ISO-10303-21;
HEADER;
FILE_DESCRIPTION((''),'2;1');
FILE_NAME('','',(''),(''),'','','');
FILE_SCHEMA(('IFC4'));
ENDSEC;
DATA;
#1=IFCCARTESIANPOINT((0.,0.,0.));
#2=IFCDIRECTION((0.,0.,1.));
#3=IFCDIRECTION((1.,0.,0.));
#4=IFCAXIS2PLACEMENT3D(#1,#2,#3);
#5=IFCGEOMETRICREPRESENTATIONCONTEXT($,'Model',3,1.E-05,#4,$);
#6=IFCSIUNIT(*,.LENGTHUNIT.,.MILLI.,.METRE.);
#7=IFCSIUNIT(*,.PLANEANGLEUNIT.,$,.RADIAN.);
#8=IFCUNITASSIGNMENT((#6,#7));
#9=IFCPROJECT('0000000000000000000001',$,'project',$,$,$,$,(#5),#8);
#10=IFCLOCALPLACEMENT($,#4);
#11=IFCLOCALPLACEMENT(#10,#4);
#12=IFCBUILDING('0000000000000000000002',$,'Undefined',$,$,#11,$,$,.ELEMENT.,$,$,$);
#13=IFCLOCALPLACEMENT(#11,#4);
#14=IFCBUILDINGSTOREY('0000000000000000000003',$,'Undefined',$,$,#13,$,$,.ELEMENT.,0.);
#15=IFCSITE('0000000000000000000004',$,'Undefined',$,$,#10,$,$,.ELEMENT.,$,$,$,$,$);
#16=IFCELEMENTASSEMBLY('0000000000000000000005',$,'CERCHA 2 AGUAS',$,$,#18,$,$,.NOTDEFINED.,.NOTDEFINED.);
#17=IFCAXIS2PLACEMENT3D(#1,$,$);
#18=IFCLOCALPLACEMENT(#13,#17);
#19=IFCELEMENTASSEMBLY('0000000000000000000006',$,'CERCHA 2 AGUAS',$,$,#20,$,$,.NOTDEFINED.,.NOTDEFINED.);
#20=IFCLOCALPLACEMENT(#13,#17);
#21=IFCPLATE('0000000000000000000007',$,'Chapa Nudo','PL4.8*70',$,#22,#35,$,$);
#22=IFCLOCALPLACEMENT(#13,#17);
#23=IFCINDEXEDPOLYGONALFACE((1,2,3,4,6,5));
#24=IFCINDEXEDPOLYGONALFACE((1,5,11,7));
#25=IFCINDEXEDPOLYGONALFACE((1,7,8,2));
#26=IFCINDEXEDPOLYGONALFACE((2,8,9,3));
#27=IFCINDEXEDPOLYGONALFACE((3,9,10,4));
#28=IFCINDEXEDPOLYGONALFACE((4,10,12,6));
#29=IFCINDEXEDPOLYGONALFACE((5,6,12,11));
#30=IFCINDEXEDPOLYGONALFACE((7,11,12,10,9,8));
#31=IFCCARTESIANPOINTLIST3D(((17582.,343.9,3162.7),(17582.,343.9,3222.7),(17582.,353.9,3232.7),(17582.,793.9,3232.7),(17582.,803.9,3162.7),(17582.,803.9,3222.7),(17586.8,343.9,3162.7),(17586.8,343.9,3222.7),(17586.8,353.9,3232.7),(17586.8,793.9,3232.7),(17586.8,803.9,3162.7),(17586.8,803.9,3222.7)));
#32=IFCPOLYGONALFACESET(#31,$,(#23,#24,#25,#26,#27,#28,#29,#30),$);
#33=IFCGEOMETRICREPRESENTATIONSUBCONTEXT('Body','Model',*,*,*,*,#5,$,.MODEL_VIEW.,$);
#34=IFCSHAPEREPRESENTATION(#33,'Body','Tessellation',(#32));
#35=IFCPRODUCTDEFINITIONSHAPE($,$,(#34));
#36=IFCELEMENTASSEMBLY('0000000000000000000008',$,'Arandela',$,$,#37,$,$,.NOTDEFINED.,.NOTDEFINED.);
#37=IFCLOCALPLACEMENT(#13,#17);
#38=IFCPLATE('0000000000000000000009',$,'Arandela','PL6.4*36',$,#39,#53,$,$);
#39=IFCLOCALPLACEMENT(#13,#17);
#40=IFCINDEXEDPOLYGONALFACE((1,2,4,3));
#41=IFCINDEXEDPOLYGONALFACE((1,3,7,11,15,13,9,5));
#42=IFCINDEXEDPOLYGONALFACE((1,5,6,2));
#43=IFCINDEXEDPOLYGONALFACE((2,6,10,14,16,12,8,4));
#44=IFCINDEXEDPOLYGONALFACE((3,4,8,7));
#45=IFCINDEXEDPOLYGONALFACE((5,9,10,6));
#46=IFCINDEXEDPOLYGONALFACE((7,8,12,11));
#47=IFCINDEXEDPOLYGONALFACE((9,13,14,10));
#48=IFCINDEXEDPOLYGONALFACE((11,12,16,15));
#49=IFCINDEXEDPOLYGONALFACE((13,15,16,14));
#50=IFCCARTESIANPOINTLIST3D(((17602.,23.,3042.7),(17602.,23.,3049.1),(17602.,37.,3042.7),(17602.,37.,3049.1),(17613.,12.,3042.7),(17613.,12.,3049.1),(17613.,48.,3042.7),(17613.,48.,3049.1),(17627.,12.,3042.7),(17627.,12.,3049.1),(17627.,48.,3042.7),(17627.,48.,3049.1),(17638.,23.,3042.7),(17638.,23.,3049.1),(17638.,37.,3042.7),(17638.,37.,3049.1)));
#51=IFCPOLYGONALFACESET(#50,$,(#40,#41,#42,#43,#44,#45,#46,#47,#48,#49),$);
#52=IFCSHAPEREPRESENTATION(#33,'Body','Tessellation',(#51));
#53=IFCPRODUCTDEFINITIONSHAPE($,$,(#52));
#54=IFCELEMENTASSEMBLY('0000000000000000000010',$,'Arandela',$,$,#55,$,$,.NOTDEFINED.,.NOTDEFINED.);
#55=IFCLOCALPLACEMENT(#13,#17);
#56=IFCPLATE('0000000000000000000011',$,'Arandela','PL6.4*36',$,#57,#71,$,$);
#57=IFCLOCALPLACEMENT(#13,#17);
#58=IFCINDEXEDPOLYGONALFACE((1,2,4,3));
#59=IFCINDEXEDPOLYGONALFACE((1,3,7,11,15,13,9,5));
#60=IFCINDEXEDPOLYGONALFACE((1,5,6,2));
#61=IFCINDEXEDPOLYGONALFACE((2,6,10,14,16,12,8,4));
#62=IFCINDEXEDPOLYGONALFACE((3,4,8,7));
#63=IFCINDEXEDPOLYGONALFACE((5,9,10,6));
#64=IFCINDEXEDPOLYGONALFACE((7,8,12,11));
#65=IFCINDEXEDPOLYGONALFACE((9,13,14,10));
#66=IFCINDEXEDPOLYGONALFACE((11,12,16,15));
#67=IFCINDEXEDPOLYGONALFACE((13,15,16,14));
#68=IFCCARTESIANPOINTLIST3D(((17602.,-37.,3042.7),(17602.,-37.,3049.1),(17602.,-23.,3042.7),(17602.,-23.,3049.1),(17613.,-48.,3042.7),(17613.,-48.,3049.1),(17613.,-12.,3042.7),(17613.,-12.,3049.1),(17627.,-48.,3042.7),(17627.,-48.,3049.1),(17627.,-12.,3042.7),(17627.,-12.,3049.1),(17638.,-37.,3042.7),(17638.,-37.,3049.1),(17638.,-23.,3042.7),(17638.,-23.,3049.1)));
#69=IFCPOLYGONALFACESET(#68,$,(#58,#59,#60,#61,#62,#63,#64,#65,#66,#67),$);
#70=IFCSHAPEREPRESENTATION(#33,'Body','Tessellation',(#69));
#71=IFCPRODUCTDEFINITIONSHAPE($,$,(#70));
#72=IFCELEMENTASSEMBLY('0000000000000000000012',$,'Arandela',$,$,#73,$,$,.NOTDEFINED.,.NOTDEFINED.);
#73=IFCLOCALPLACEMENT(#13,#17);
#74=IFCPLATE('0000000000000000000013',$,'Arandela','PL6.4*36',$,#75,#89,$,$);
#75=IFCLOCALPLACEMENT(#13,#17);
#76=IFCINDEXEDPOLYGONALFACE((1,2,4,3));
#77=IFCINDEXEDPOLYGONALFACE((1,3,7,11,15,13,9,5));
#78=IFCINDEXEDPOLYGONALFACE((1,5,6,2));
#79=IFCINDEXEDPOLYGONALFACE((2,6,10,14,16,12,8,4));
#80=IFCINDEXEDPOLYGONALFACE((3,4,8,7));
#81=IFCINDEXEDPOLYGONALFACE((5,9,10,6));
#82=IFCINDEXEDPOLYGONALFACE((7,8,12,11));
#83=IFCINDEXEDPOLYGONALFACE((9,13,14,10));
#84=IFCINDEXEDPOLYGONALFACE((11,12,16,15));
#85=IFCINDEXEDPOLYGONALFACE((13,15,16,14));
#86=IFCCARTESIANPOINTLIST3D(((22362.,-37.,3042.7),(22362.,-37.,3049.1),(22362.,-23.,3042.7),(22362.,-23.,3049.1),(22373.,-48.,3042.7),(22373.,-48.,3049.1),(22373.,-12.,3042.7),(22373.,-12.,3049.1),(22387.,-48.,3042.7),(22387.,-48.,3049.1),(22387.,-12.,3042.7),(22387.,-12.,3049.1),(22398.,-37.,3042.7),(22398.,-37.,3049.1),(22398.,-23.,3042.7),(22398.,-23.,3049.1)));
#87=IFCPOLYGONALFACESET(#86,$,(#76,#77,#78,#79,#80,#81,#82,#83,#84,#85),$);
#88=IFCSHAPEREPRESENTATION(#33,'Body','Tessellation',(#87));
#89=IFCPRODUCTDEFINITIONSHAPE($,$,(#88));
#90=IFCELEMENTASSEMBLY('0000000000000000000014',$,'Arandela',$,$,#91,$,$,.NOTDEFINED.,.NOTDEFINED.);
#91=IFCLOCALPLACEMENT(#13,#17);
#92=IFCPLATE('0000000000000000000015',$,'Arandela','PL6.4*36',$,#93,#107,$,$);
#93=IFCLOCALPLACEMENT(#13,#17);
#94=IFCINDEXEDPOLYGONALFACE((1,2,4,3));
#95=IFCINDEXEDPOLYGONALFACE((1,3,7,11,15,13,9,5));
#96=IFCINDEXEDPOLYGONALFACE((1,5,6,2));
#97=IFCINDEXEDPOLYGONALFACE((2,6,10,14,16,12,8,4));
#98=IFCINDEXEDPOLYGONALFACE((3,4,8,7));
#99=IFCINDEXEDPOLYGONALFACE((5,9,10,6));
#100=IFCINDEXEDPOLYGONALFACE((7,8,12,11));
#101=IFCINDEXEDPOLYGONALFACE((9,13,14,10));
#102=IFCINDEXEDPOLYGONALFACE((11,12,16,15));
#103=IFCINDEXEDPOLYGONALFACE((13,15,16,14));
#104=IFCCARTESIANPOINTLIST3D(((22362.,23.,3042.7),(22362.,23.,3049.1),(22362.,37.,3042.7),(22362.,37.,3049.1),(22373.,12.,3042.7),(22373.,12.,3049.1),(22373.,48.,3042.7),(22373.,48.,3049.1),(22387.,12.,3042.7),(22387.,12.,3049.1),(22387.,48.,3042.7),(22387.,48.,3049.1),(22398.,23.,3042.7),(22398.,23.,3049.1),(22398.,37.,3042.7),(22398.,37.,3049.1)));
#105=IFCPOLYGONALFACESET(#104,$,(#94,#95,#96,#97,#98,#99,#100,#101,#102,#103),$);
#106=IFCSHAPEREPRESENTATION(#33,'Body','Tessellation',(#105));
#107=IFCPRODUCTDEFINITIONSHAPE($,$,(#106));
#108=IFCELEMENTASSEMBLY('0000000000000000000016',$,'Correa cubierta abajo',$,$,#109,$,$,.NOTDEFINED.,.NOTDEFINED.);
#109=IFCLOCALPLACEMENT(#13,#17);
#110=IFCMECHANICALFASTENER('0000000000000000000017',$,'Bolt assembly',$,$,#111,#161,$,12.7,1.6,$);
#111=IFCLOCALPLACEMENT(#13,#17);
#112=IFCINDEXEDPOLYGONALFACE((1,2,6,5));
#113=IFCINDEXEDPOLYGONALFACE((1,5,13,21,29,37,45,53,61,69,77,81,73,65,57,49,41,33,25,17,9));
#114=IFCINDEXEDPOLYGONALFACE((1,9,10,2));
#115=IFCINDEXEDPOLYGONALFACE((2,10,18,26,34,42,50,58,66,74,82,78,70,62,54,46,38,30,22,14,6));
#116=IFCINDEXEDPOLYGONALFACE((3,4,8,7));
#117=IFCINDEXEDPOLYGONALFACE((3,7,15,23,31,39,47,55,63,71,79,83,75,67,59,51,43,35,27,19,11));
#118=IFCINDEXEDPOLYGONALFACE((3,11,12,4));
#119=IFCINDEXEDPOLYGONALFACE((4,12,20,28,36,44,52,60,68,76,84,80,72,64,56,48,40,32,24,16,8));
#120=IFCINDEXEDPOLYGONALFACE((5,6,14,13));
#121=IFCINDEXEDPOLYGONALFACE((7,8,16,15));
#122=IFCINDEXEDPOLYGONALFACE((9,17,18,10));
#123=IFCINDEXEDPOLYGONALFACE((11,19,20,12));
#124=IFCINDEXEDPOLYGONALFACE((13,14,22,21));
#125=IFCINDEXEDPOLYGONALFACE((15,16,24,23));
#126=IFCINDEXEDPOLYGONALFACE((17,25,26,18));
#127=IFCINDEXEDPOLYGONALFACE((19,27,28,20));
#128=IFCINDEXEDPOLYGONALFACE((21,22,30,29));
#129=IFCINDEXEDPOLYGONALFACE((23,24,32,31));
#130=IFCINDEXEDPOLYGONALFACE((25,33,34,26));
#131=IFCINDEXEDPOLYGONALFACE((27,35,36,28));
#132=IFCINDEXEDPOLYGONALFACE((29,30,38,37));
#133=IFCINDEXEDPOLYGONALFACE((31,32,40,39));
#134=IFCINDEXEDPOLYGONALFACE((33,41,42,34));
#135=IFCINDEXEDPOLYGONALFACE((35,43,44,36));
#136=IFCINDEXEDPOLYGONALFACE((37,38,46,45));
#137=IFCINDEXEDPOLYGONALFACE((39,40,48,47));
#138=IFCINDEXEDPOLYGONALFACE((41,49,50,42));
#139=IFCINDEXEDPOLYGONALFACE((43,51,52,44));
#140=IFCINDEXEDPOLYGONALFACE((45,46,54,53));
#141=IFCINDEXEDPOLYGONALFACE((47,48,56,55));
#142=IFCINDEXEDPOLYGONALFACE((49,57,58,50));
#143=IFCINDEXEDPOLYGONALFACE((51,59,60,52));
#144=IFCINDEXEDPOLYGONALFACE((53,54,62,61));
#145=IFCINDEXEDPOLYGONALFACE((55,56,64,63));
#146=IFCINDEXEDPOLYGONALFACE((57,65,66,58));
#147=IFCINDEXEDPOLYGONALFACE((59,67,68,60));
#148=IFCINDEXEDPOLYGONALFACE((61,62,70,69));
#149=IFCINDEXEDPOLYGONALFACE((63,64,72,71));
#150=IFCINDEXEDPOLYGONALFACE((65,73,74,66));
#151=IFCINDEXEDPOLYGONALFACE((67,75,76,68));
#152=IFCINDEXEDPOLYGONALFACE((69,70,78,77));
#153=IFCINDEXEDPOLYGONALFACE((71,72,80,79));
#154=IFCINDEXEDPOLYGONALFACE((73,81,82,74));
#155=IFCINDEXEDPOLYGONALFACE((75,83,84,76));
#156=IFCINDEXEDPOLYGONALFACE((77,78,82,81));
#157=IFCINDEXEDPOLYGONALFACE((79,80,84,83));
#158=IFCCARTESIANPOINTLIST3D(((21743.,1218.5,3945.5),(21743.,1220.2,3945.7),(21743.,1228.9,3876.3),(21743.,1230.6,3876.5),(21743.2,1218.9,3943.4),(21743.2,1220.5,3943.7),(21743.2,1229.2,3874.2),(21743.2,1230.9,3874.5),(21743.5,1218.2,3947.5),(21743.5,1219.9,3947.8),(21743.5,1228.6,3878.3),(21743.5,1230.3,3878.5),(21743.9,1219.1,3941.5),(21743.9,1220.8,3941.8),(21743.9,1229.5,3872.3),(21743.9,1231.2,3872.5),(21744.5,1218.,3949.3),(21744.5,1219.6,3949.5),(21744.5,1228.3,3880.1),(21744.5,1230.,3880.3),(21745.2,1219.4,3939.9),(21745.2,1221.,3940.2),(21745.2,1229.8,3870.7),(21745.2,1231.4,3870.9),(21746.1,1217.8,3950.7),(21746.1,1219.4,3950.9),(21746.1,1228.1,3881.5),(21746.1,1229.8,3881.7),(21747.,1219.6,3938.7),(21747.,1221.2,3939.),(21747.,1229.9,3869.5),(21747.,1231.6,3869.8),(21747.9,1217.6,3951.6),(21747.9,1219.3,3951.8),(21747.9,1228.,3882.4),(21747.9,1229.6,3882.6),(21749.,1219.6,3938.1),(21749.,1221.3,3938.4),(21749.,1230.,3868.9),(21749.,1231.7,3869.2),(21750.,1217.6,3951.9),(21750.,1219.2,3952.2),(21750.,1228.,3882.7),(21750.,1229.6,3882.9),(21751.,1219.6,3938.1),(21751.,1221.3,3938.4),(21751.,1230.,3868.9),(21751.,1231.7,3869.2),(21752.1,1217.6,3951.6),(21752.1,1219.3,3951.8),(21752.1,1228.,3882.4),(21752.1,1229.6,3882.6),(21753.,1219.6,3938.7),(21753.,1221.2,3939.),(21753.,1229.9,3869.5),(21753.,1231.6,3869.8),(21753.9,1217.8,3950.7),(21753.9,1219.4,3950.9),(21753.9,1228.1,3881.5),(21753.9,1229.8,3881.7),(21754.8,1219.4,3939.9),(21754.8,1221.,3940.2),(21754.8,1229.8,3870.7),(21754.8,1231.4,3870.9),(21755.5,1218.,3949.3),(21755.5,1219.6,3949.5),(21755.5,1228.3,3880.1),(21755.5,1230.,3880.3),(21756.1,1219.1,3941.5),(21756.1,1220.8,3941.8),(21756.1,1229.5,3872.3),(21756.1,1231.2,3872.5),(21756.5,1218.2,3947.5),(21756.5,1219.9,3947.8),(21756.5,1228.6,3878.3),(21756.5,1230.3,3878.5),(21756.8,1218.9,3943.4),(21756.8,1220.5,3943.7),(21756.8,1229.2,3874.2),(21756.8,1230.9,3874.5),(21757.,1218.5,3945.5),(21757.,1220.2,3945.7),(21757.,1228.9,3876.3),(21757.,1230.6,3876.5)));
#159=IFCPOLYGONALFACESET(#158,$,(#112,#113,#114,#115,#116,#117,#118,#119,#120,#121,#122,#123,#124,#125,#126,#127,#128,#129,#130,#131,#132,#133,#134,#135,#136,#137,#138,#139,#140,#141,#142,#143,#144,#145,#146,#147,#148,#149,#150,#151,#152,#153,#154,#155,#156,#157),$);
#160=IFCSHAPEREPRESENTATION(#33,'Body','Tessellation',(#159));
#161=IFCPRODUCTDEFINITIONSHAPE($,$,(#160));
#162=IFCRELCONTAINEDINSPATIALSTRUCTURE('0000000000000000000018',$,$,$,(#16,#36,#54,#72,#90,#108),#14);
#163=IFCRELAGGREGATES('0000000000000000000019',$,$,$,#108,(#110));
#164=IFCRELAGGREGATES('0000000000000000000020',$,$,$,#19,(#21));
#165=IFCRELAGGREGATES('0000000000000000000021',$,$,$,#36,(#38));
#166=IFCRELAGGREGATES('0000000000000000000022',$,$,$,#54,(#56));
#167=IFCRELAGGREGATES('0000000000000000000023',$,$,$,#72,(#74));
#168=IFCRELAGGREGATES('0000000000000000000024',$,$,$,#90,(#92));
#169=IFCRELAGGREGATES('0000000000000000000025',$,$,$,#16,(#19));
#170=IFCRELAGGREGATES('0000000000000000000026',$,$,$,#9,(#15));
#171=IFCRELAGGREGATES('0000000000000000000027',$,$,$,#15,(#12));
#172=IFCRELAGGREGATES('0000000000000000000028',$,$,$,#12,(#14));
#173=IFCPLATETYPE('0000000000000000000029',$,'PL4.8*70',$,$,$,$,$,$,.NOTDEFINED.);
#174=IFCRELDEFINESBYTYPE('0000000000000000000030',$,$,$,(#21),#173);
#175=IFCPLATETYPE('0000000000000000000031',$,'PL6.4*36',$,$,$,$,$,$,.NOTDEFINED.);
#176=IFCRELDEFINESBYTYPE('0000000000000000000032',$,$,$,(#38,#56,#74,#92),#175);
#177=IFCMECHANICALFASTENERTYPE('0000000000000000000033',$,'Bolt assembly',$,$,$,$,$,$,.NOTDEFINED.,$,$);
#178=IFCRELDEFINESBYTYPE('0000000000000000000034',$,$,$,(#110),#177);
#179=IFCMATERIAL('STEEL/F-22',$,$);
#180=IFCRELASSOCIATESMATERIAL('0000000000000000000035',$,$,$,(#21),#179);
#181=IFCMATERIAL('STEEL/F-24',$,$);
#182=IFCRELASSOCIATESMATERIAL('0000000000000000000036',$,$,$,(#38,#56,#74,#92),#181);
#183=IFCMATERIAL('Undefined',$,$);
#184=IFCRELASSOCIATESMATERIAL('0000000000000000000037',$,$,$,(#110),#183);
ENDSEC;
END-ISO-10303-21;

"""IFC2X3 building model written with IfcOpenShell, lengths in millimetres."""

from ifc_helpers import new_model, si_unit, frame, origin_with_axes, origin_2d_with_axis, place, context, subcontext, project, spatial, polyline, circle, outline, extrude, source, transform, mapped, material, type_object, element, aggregate, save


model = new_model("IFC2X3")

# Units and contexts
model_context = context("Model", 3, precision=1e-05, world=origin_with_axes())
body_context = subcontext(model_context, "Body", "Model", "MODEL_VIEW")
ifc_project = project(units=[si_unit("LENGTHUNIT", "METRE", prefix="MILLI"), si_unit("PLANEANGLEUNIT", "RADIAN")], contexts=[model_context])

# Site, building, storey
site_placement = place(None, origin_with_axes())
site = spatial("IfcSite", under=ifc_project, at=site_placement, Name="Undefined", CompositionType="ELEMENT")
building_placement = place(site_placement, origin_with_axes())
building = spatial("IfcBuilding", under=site, at=building_placement, Name="Undefined", CompositionType="ELEMENT")
storey_placement = place(building_placement, origin_with_axes())
storey = spatial("IfcBuildingStorey", under=building, at=storey_placement, Name="Undefined", CompositionType="ELEMENT", Elevation=0.0)

# Element assemblies
assembly_1_placement = place(storey_placement, origin_with_axes())
assembly_1 = element("IfcElementAssembly", 1, at=assembly_1_placement, inside=storey, Name="CERCHA 2 AGUAS", AssemblyPlace="NOTDEFINED", PredefinedType="NOTDEFINED")
assembly_2_placement = place(assembly_1_placement, origin_with_axes())
assembly_2 = element("IfcElementAssembly", 2, at=assembly_2_placement, Name="CERCHA 2 AGUAS", AssemblyPlace="NOTDEFINED", PredefinedType="NOTDEFINED")
ifc_material_1 = material(Name="STEEL/F-22")

# Plate
ifc_material_2 = material(Name="STEEL/F-24")
plate_type_1 = type_object("IfcPlateType", Name="PL4.8*70", PredefinedType="NOTDEFINED")
plate_1_placement = place(assembly_2_placement, frame((17584.4, 343.9, 3232.7), z_axis=(1.0, 0.0, 0.0), x_axis=(0.0, 0.0, -1.0)))
plate_1 = element("IfcPlate", 3, at=plate_1_placement, type_object=plate_type_1, material=ifc_material_1, Name="Chapa Nudo", Description="PL4.8*70", context=body_context, shape_type="SweptSolid", body=[
    extrude(outline(polyline([(0.0, 10.0), (10.0, 0.0), (70.0, 0.0), (70.0, 460.0), (10.0, 460.0), (0.0, 450.0), (0.0, 10.0)])), frame((0.0, 0.0, -2.4), z_axis=(0.0, 0.0, 1.0), x_axis=(1.0, 0.0, 0.0)), (0.0, 0.0, 1.0), 4.8),
])

# Element assemblies, plates
assembly_3_placement = place(storey_placement, origin_with_axes())
assembly_3 = element("IfcElementAssembly", 4, at=assembly_3_placement, inside=storey, Name="Arandela", AssemblyPlace="NOTDEFINED", PredefinedType="NOTDEFINED")
plate_type_2 = type_object("IfcPlateType", Name="PL6.4*36", PredefinedType="NOTDEFINED")
plate_2_placement = place(assembly_3_placement, frame((17602.0, 48.0, 3045.9), z_axis=(0.0, 0.0, 1.0), x_axis=(0.0, -1.0, 0.0)))
plate_2 = element("IfcPlate", 5, at=plate_2_placement, type_object=plate_type_2, material=ifc_material_2, Name="Arandela", Description="PL6.4*36", context=body_context, shape_type="SweptSolid", body=[
    extrude(outline(polyline([(0.0, 11.0), (11.0, 0.0), (25.0, 0.0), (36.0, 11.0), (36.0, 25.0), (25.0, 36.0), (11.0, 36.0), (0.0, 25.0), (0.0, 11.0)])), frame((0.0, 0.0, -3.2), z_axis=(0.0, 0.0, 1.0), x_axis=(1.0, 0.0, 0.0)), (0.0, 0.0, 1.0), 6.4),
])
assembly_4_placement = place(storey_placement, origin_with_axes())
assembly_4 = element("IfcElementAssembly", 6, at=assembly_4_placement, inside=storey, Name="Arandela", AssemblyPlace="NOTDEFINED", PredefinedType="NOTDEFINED")
plate_3_placement = place(assembly_4_placement, frame((17602.0, -12.0, 3045.9), z_axis=(0.0, 0.0, 1.0), x_axis=(0.0, -1.0, 0.0)))
plate_3 = element("IfcPlate", 7, at=plate_3_placement, type_object=plate_type_2, material=ifc_material_2, Name="Arandela", Description="PL6.4*36", context=body_context, shape_type="SweptSolid", body=[
    extrude(outline(polyline([(0.0, 11.0), (11.0, 0.0), (25.0, 0.0), (36.0, 11.0), (36.0, 25.0), (25.0, 36.0), (11.0, 36.0), (0.0, 25.0), (0.0, 11.0)])), frame((0.0, 0.0, -3.2), z_axis=(0.0, 0.0, 1.0), x_axis=(1.0, 0.0, 0.0)), (0.0, 0.0, 1.0), 6.4),
])
assembly_5_placement = place(storey_placement, origin_with_axes())
assembly_5 = element("IfcElementAssembly", 8, at=assembly_5_placement, inside=storey, Name="Arandela", AssemblyPlace="NOTDEFINED", PredefinedType="NOTDEFINED")
plate_4_placement = place(assembly_5_placement, frame((22362.0, -12.0, 3045.9), z_axis=(0.0, 0.0, 1.0), x_axis=(0.0, -1.0, 0.0)))
plate_4 = element("IfcPlate", 9, at=plate_4_placement, type_object=plate_type_2, material=ifc_material_2, Name="Arandela", Description="PL6.4*36", context=body_context, shape_type="SweptSolid", body=[
    extrude(outline(polyline([(0.0, 11.0), (11.0, 0.0), (25.0, 0.0), (36.0, 11.0), (36.0, 25.0), (25.0, 36.0), (11.0, 36.0), (0.0, 25.0), (0.0, 11.0)])), frame((0.0, 0.0, -3.2), z_axis=(0.0, 0.0, 1.0), x_axis=(1.0, 0.0, 0.0)), (0.0, 0.0, 1.0), 6.4),
])
assembly_6_placement = place(storey_placement, origin_with_axes())
assembly_6 = element("IfcElementAssembly", 10, at=assembly_6_placement, inside=storey, Name="Arandela", AssemblyPlace="NOTDEFINED", PredefinedType="NOTDEFINED")
plate_5_placement = place(assembly_6_placement, frame((22362.0, 48.0, 3045.9), z_axis=(0.0, 0.0, 1.0), x_axis=(0.0, -1.0, 0.0)))
plate_5 = element("IfcPlate", 11, at=plate_5_placement, type_object=plate_type_2, material=ifc_material_2, Name="Arandela", Description="PL6.4*36", context=body_context, shape_type="SweptSolid", body=[
    extrude(outline(polyline([(0.0, 11.0), (11.0, 0.0), (25.0, 0.0), (36.0, 11.0), (36.0, 25.0), (25.0, 36.0), (11.0, 36.0), (0.0, 25.0), (0.0, 11.0)])), frame((0.0, 0.0, -3.2), z_axis=(0.0, 0.0, 1.0), x_axis=(1.0, 0.0, 0.0)), (0.0, 0.0, 1.0), 6.4),
])

# Element assembly
assembly_7_placement = place(storey_placement, origin_with_axes())
assembly_7 = element("IfcElementAssembly", 12, at=assembly_7_placement, inside=storey, Name="Correa cubierta abajo", AssemblyPlace="NOTDEFINED", PredefinedType="NOTDEFINED")
ifc_material_3 = material(Name="Undefined")
mechanical_fastener_type = type_object("IfcMechanicalFastenerType", Name="Bolt assembly")

# Mechanical fastener
shared_shape_1 = source(origin_with_axes(), body_context, "Body", "SweptSolid", [
    extrude(circle(Radius=7.0, at=origin_2d_with_axis()), frame((0.0, 3.2, 0.0), z_axis=(0.0, 1.0, 0.0), x_axis=(1.0, 0.0, 0.0)), (0.0, 0.0, 1.0), 1.7),
])
mechanical_fastener_1_placement = place(assembly_7_placement, frame((21750.0, 1233.8, 3876.5), z_axis=(1.0, 0.0, 0.0), x_axis=(0.0, -0.148209, 0.988956)))
mechanical_fastener_1 = element("IfcMechanicalFastener", 13, at=mechanical_fastener_1_placement, type_object=mechanical_fastener_type, material=ifc_material_3, Name="Bolt assembly", NominalDiameter=12.7, NominalLength=1.6, context=body_context, shape_type="MappedRepresentation", body=[
    mapped(shared_shape_1, transform((0.0, 0.0, 0.0))),
    mapped(shared_shape_1, transform((70.0, 0.0, 0.0))),
])
aggregate(assembly_7, [mechanical_fastener_1])
aggregate(assembly_2, [plate_1])
aggregate(assembly_3, [plate_2])
aggregate(assembly_4, [plate_3])
aggregate(assembly_5, [plate_4])
aggregate(assembly_6, [plate_5])
aggregate(assembly_1, [assembly_2])

save(model, "model.ifc")
